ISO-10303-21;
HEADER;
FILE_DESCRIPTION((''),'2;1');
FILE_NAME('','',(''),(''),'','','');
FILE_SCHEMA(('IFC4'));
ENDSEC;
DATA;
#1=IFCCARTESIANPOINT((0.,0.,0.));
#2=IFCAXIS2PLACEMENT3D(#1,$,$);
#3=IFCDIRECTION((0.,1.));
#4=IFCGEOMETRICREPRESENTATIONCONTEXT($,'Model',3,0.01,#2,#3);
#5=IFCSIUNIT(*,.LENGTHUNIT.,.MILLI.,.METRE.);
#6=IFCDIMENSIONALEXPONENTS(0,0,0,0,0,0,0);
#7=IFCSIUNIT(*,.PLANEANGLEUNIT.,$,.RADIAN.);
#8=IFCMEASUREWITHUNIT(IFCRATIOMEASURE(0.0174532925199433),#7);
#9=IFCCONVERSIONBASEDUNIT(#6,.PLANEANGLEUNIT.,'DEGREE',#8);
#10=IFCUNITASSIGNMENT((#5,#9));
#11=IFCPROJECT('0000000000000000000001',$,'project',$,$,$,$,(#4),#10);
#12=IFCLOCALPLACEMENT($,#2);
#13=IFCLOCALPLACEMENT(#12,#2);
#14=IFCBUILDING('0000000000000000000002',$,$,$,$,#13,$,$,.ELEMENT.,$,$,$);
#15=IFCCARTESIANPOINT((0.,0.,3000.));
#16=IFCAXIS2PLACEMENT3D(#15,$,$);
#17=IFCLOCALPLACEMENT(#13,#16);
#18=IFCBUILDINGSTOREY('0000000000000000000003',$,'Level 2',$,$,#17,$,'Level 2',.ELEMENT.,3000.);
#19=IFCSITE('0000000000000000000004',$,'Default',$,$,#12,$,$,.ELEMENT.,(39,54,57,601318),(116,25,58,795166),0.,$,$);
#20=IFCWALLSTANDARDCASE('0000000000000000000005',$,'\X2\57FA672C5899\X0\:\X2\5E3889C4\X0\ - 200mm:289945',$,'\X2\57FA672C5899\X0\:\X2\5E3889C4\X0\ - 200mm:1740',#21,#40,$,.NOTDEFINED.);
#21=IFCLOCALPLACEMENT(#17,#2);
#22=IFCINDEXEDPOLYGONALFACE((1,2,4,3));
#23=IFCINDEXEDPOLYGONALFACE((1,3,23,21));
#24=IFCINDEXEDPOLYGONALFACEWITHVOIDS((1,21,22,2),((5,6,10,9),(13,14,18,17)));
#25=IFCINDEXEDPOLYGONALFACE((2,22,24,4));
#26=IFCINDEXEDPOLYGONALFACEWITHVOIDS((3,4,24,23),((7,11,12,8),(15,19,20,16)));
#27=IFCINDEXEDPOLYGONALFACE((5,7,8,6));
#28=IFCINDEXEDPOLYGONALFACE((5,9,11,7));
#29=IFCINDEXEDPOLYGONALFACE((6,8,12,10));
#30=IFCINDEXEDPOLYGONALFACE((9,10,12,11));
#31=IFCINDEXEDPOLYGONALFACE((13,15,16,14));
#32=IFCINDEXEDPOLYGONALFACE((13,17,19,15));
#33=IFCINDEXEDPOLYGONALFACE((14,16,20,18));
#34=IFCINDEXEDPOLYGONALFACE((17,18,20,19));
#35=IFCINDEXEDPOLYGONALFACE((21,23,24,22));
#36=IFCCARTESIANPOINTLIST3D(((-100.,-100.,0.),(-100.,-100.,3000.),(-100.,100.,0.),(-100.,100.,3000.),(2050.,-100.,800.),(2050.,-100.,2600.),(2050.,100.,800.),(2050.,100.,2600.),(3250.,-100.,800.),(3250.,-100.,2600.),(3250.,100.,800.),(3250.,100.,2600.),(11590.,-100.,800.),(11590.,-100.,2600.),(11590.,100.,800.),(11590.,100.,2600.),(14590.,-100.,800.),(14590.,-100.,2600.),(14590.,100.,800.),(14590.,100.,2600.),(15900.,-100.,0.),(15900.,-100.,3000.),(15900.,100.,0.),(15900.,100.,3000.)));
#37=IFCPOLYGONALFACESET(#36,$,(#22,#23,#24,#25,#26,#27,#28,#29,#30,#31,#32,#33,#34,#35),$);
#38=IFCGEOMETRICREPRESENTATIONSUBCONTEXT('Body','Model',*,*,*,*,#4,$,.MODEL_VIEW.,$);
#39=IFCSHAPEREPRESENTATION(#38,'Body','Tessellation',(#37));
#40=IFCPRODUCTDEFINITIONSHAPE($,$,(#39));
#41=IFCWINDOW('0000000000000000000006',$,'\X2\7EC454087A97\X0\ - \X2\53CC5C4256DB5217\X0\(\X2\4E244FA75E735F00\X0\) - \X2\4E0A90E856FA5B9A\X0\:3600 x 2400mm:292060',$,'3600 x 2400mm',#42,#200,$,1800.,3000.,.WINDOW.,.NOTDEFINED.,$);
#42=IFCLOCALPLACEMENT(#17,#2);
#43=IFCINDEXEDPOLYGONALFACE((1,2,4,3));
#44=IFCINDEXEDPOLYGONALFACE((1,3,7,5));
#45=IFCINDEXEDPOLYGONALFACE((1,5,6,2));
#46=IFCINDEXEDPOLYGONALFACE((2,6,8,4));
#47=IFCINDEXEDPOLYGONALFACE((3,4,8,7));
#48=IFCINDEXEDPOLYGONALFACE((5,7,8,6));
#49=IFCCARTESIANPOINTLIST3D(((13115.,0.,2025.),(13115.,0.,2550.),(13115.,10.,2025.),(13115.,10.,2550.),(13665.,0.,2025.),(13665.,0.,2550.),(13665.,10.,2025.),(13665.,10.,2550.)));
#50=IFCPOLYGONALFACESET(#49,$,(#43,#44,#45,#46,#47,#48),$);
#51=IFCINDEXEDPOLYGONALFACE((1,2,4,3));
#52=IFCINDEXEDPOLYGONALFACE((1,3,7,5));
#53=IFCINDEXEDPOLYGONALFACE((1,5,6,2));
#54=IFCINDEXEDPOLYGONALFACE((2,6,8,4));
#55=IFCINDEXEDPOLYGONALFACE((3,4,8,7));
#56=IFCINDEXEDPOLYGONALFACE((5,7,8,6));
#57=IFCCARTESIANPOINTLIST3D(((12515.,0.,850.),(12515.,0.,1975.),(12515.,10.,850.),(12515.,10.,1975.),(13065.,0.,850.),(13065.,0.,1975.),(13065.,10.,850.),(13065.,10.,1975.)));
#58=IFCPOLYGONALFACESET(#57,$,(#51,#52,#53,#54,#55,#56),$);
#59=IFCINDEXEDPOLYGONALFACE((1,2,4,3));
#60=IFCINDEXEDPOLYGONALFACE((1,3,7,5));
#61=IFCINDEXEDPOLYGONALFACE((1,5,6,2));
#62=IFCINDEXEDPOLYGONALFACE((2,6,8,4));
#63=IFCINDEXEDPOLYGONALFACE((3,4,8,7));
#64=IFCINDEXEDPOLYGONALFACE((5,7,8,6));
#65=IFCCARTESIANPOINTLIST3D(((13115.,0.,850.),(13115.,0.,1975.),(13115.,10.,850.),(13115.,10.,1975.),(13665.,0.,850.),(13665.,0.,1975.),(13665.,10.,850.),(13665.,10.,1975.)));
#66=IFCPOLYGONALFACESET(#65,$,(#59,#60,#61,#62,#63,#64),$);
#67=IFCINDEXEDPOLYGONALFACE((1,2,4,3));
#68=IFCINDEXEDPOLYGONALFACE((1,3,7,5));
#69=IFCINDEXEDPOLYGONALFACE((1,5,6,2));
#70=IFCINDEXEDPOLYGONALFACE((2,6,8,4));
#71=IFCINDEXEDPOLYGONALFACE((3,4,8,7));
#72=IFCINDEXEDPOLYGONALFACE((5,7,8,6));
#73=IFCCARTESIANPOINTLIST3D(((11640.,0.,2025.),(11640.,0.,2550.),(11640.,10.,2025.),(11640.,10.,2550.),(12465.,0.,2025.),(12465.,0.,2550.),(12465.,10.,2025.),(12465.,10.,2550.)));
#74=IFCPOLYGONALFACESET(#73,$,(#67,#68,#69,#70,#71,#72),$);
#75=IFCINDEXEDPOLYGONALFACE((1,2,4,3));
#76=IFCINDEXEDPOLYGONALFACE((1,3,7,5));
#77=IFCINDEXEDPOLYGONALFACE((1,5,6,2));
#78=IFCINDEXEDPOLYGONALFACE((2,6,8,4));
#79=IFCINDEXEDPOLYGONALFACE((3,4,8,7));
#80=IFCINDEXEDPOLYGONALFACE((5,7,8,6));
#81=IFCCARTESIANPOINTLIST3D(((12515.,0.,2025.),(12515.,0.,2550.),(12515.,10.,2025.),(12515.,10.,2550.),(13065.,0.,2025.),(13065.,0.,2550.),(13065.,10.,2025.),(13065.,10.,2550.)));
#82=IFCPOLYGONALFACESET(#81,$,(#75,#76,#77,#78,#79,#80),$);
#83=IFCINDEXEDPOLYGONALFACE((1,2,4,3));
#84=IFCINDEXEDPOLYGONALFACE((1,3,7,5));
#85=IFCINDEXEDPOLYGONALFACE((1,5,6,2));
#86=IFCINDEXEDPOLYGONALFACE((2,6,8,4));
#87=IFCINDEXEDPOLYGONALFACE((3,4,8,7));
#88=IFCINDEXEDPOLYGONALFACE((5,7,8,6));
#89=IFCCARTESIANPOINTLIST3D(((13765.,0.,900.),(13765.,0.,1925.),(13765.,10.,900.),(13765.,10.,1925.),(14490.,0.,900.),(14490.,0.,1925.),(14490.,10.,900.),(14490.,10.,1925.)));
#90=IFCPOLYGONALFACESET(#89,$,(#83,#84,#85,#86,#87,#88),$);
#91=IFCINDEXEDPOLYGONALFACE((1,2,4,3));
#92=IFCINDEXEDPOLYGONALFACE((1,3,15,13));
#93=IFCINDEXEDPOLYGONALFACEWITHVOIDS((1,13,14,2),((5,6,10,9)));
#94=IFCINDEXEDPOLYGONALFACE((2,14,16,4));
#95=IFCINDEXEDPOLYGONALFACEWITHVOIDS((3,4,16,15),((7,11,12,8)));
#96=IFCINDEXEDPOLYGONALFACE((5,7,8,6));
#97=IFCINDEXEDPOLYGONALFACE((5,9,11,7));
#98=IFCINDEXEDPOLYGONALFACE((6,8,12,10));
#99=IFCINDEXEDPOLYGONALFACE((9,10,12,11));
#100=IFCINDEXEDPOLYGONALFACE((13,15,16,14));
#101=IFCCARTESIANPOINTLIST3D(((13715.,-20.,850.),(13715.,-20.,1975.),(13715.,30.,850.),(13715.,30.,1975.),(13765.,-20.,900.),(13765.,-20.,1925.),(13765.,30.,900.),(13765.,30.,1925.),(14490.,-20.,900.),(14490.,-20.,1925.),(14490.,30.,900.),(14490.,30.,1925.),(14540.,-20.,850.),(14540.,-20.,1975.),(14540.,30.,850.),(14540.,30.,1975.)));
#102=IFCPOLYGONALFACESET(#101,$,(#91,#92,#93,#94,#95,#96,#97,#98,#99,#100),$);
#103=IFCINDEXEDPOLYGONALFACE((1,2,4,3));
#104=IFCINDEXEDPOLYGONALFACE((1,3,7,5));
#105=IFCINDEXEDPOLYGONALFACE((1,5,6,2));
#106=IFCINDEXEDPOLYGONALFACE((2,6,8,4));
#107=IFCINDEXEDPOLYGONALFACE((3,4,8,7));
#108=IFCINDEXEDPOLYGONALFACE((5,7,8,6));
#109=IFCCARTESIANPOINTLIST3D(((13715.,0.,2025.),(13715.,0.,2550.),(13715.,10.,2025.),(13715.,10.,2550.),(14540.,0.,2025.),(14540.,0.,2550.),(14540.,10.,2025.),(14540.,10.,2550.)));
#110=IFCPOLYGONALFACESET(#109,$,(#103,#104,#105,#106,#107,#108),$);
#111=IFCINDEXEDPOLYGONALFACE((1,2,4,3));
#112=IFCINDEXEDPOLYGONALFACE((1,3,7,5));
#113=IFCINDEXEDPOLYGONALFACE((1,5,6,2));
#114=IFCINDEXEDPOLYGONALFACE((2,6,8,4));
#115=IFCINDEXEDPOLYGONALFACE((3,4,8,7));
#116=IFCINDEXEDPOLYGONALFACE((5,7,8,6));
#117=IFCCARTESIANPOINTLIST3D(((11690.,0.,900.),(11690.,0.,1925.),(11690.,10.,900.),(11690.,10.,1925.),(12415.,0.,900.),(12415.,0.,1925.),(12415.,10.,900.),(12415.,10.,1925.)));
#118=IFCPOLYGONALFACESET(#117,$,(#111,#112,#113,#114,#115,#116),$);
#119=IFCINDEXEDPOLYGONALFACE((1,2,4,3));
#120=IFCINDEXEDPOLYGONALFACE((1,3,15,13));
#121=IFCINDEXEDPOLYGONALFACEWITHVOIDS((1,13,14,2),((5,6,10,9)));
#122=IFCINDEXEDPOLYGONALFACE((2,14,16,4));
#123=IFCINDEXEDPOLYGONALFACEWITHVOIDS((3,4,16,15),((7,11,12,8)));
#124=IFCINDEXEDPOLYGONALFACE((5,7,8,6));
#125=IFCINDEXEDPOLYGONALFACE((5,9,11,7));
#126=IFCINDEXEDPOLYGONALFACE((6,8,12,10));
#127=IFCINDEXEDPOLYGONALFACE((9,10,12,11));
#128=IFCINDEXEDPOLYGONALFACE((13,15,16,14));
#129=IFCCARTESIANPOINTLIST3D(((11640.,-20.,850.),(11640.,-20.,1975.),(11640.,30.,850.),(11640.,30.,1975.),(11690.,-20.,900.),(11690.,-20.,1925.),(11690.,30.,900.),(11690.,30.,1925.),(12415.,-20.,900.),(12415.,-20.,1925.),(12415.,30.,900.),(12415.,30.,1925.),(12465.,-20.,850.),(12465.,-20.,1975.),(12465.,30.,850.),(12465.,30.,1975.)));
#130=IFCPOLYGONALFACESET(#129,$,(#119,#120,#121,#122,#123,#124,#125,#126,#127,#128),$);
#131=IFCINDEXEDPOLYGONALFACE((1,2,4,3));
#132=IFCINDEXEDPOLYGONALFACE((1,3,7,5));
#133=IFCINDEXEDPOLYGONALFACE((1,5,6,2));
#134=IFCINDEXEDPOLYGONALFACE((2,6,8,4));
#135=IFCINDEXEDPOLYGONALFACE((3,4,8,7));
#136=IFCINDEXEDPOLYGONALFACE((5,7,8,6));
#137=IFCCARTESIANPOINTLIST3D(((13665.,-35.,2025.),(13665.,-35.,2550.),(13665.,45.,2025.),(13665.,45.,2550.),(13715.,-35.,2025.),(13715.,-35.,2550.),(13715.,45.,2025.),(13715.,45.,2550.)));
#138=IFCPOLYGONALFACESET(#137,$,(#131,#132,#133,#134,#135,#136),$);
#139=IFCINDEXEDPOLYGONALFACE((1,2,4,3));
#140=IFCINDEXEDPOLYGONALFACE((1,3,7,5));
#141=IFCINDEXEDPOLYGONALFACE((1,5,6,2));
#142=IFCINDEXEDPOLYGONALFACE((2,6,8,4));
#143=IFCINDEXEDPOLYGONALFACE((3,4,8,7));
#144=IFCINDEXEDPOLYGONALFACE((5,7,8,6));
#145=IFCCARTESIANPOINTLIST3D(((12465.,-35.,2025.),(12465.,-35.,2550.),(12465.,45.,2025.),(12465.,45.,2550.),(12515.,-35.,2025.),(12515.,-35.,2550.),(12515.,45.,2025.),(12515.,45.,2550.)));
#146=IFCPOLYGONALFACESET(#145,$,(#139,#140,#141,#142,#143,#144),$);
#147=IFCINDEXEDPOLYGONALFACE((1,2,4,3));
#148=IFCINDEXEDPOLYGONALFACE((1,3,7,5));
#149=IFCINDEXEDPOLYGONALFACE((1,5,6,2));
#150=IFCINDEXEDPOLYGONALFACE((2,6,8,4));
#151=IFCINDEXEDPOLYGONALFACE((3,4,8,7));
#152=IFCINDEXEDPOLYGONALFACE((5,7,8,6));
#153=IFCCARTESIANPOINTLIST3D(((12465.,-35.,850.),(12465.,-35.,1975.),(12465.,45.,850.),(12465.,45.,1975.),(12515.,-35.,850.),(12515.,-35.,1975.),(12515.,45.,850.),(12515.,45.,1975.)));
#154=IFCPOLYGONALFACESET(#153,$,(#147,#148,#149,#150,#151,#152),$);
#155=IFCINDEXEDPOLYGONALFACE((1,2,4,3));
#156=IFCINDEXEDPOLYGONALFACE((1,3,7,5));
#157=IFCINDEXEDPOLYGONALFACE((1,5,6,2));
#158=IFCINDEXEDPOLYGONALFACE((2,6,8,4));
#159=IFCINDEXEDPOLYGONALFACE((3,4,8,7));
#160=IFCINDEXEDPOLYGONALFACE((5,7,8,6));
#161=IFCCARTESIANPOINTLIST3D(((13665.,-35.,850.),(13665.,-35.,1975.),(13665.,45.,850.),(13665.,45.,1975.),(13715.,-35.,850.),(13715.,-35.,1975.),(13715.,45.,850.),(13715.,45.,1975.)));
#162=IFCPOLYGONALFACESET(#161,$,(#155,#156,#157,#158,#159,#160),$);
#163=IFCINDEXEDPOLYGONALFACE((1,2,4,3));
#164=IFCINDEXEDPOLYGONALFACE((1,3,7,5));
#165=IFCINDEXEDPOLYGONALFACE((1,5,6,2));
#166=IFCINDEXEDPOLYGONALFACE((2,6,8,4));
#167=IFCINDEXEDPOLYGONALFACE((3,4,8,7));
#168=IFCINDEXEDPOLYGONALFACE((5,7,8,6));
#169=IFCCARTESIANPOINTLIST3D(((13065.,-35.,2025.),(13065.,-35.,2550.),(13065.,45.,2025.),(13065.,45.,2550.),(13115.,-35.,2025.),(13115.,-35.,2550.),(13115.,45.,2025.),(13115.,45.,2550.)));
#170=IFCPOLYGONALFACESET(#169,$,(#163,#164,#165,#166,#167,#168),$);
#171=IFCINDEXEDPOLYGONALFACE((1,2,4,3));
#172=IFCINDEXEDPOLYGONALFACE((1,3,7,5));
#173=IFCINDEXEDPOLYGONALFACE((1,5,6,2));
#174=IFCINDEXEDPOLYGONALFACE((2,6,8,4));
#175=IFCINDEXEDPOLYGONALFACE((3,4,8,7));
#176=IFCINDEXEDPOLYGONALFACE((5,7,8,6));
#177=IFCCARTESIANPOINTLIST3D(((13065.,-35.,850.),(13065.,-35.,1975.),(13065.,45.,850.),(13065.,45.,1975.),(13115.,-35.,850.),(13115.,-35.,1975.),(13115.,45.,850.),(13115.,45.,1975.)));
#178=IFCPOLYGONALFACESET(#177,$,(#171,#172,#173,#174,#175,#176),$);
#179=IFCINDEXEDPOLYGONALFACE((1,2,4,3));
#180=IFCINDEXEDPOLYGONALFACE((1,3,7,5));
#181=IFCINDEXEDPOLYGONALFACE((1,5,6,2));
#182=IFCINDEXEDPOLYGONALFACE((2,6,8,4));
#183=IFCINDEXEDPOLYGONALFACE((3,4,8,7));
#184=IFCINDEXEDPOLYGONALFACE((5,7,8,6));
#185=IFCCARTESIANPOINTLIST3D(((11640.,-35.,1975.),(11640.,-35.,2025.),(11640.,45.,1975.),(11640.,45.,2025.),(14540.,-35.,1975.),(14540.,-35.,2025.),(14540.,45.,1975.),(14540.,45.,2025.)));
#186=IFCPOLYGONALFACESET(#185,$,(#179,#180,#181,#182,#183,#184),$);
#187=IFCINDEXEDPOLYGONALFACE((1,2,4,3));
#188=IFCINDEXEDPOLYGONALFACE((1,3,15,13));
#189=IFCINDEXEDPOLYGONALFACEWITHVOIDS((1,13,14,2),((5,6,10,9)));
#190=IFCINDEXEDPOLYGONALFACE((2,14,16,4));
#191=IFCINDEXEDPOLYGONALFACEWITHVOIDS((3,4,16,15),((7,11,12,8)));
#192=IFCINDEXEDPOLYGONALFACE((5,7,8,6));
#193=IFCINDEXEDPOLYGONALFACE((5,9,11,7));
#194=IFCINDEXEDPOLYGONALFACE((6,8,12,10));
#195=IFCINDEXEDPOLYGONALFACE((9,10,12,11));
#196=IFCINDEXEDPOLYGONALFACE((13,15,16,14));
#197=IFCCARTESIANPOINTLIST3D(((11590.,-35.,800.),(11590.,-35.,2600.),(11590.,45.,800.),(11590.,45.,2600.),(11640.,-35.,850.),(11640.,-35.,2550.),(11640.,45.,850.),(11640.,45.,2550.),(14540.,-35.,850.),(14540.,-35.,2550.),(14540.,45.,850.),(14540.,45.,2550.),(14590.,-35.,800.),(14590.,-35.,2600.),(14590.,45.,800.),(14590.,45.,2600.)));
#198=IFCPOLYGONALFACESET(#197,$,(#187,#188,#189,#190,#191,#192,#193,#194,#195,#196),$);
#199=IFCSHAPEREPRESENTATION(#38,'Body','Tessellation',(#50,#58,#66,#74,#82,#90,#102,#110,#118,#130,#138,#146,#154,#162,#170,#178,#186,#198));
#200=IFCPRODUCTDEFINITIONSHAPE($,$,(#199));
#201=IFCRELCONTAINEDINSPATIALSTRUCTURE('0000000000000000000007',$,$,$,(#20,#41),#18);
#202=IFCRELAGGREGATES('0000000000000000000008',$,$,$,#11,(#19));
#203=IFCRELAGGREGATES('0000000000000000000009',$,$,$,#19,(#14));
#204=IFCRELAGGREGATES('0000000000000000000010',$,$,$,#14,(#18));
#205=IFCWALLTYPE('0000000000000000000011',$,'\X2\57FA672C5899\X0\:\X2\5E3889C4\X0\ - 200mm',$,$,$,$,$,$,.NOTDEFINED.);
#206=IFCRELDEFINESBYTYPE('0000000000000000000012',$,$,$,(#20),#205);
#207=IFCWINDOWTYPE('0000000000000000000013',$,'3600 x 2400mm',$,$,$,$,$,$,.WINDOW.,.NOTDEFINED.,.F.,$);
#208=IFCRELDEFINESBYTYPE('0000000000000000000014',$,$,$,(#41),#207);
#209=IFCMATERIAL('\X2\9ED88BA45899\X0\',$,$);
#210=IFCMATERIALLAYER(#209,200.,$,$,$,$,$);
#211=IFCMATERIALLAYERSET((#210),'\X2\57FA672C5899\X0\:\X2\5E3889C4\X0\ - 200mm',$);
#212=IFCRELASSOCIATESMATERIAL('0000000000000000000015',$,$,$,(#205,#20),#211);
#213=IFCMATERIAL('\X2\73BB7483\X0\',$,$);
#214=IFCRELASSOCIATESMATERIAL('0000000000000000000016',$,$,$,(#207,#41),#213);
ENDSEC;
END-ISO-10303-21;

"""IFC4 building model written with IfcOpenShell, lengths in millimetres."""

from ifc_helpers import new_model, entity, si_unit, converted_unit, direction, frame, frame_2d, origin, origin_2d_with_axis, place, context, subcontext, project, spatial, polyline, rectangle, outline, extrude, source, transform, mapped, material, layer, layer_set, layer_usage, type_object, type_shapes, element, fill, save


model = new_model("IFC4")

# Units and contexts
model_context = context("Model", 3, precision=0.01, world=origin(), true_north=direction((0.0, 1.0)))
body_context = subcontext(model_context, "Body", "Model", "MODEL_VIEW")
ifc_project = project(units=[si_unit("LENGTHUNIT", "METRE", prefix="MILLI"), converted_unit("PLANEANGLEUNIT", "DEGREE", entity("IfcRatioMeasure", 0.0174532925199433), si_unit("PLANEANGLEUNIT", "RADIAN"), dimensions=[0, 0, 0, 0, 0, 0, 0])], contexts=[model_context])

# Site, building, storey
site_placement = place(None, origin())
site = spatial("IfcSite", under=ifc_project, at=site_placement, Name="Default", CompositionType="ELEMENT", RefLatitude=(39, 54, 57, 601318), RefLongitude=(116, 25, 58, 795166), RefElevation=0.0)
building_placement = place(site_placement, origin())
building = spatial("IfcBuilding", under=site, at=building_placement, CompositionType="ELEMENT")
storey_placement = place(building_placement, frame((0.0, 0.0, 3000.0)))
storey = spatial("IfcBuildingStorey", under=building, at=storey_placement, Name="Level 2", LongName="Level 2", CompositionType="ELEMENT", Elevation=3000.0)

# Shared definitions
ifc_material_1 = material(Name="默认墙")
ifc_layer = layer(ifc_material_1, 200.0)
ifc_layer_set = layer_set([ifc_layer], Name="基本墙:常规 - 200mm")
wall_type = type_object("IfcWallType", Name="基本墙:常规 - 200mm", PredefinedType="NOTDEFINED", material=ifc_layer_set)

# Shared definitions
ifc_material_2 = material(Name="玻璃")

# Wall, openings, window
ifc_layer_usage_1 = layer_usage(ifc_layer_set, "AXIS2", "NEGATIVE", 100.0)
wall_1_placement = place(storey_placement, frame((15900.0, 0.0, 0.0), z_axis=(0.0, 0.0, 1.0), x_axis=(-1.0, 0.0, 0.0)))
wall_1 = element("IfcWallStandardCase", 1, at=wall_1_placement, inside=storey, type_object=wall_type, material=ifc_layer_usage_1, Name="基本墙:常规 - 200mm:289945", ObjectType="基本墙:常规 - 200mm:1740", PredefinedType="NOTDEFINED", context=body_context, shape_type="SweptSolid", body=[
    extrude(rectangle(XDim=16000.0, YDim=200.0, at=frame_2d((8000.0, 0.0), x_axis=(-1.0, 0.0))), origin(), (0.0, 0.0, 1.0), 3000.0),
])
opening_1_placement = place(wall_1_placement, frame((12650.0, -100.0, 800.0)))
element("IfcOpeningElement", 2, at=opening_1_placement, cuts=wall_1, ObjectType="Opening", PredefinedType="OPENING", context=body_context, shape_type="SweptSolid", body=[
    extrude(rectangle(XDim=1800.0, YDim=1200.0, at=frame_2d((900.0, 600.0), x_axis=(1.0, 0.0))), frame((0.0, 0.0, 0.0), z_axis=(0.0, 1.0, 0.0), x_axis=(0.0, 0.0, 1.0)), (0.0, 0.0, 1.0), 200.0),
])
opening_2_placement = place(wall_1_placement, frame((1310.0, -100.0, 800.0)))
opening_2 = element("IfcOpeningElement", 3, at=opening_2_placement, cuts=wall_1, ObjectType="Opening", PredefinedType="OPENING", context=body_context, shape_type="SweptSolid", body=[
    extrude(rectangle(XDim=1800.0, YDim=3000.0, at=frame_2d((900.0, 1500.0), x_axis=(1.0, 0.0))), frame((0.0, 0.0, 0.0), z_axis=(0.0, 1.0, 0.0), x_axis=(0.0, 0.0, 1.0)), (0.0, 0.0, 1.0), 200.0),
])
window_type_1 = type_object("IfcWindowType", Name="3600 x 2400mm", ParameterTakesPrecedence=False, PartitioningType="NOTDEFINED", PredefinedType="WINDOW", material=ifc_material_2)
shared_shape_1 = source(origin(), body_context, "Body", "SweptSolid", [
    extrude(rectangle(XDim=10.0, YDim=550.0, at=origin_2d_with_axis()), frame((1200.0, 95.0, 1225.0), z_axis=(0.0, 0.0, 1.0), x_axis=(0.0, 1.0, 0.0)), (0.0, 0.0, 1.0), 525.0),
    extrude(rectangle(XDim=10.0, YDim=550.0, at=origin_2d_with_axis()), frame((1800.0, 95.0, 50.0), z_axis=(0.0, 0.0, 1.0), x_axis=(0.0, 1.0, 0.0)), (0.0, 0.0, 1.0), 1125.0),
    extrude(rectangle(XDim=10.0, YDim=550.0, at=origin_2d_with_axis()), frame((1200.0, 95.0, 50.0), z_axis=(0.0, 0.0, 1.0), x_axis=(0.0, 1.0, 0.0)), (0.0, 0.0, 1.0), 1125.0),
    extrude(rectangle(XDim=10.0, YDim=825.0, at=origin_2d_with_axis()), frame((2537.5, 95.0, 1225.0), z_axis=(0.0, 0.0, 1.0), x_axis=(0.0, 1.0, 0.0)), (0.0, 0.0, 1.0), 525.0),
    extrude(rectangle(XDim=10.0, YDim=550.0, at=origin_2d_with_axis()), frame((1800.0, 95.0, 1225.0), z_axis=(0.0, 0.0, 1.0), x_axis=(0.0, 1.0, 0.0)), (0.0, 0.0, 1.0), 525.0),
    extrude(rectangle(XDim=10.0, YDim=725.0, at=origin_2d_with_axis()), frame((462.5, 95.0, 100.0), z_axis=(0.0, 0.0, 1.0), x_axis=(0.0, 1.0, 0.0)), (0.0, 0.0, 1.0), 1025.0),
    extrude(outline(polyline([(-562.5, -412.5), (562.5, -412.5), (562.5, 412.5), (-562.5, 412.5), (-562.5, -412.5)]), holes=[polyline([(512.5, -362.5), (-512.5, -362.5), (-512.5, 362.5), (512.5, 362.5), (512.5, -362.5)])]), frame((462.5, 70.0, 612.5), z_axis=(0.0, 1.0, 0.0), x_axis=(0.0, 0.0, -1.0)), (0.0, 0.0, 1.0), 50.0),
    extrude(rectangle(XDim=10.0, YDim=825.0, at=origin_2d_with_axis()), frame((462.5, 95.0, 1225.0), z_axis=(0.0, 0.0, 1.0), x_axis=(0.0, 1.0, 0.0)), (0.0, 0.0, 1.0), 525.0),
    extrude(rectangle(XDim=10.0, YDim=725.0, at=origin_2d_with_axis()), frame((2537.5, 95.0, 100.0), z_axis=(0.0, 0.0, 1.0), x_axis=(0.0, 1.0, 0.0)), (0.0, 0.0, 1.0), 1025.0),
    extrude(outline(polyline([(-562.5, -412.5), (562.5, -412.5), (562.5, 412.5), (-562.5, 412.5), (-562.5, -412.5)]), holes=[polyline([(512.5, -362.5), (-512.5, -362.5), (-512.5, 362.5), (512.5, 362.5), (512.5, -362.5)])]), frame((2537.5, 70.0, 612.5), z_axis=(0.0, 1.0, 0.0), x_axis=(0.0, 0.0, -1.0)), (0.0, 0.0, 1.0), 50.0),
    extrude(rectangle(XDim=80.0, YDim=50.0, at=origin_2d_with_axis()), frame((900.0, 95.0, 1225.0), z_axis=(0.0, 0.0, 1.0), x_axis=(0.0, -1.0, 0.0)), (0.0, 0.0, 1.0), 525.0),
    extrude(rectangle(XDim=80.0, YDim=50.0, at=origin_2d_with_axis()), frame((2100.0, 95.0, 1225.0), z_axis=(0.0, 0.0, 1.0), x_axis=(0.0, -1.0, 0.0)), (0.0, 0.0, 1.0), 525.0),
    extrude(rectangle(XDim=80.0, YDim=50.0, at=origin_2d_with_axis()), frame((2100.0, 95.0, 50.0), z_axis=(0.0, 0.0, 1.0), x_axis=(0.0, -1.0, 0.0)), (0.0, 0.0, 1.0), 1125.0),
    extrude(rectangle(XDim=80.0, YDim=50.0, at=origin_2d_with_axis()), frame((900.0, 95.0, 50.0), z_axis=(0.0, 0.0, 1.0), x_axis=(0.0, -1.0, 0.0)), (0.0, 0.0, 1.0), 1125.0),
    extrude(rectangle(XDim=80.0, YDim=50.0, at=origin_2d_with_axis()), frame((1500.0, 95.0, 1225.0), z_axis=(0.0, 0.0, 1.0), x_axis=(0.0, -1.0, 0.0)), (0.0, 0.0, 1.0), 525.0),
    extrude(rectangle(XDim=80.0, YDim=50.0, at=origin_2d_with_axis()), frame((1500.0, 95.0, 50.0), z_axis=(0.0, 0.0, 1.0), x_axis=(0.0, -1.0, 0.0)), (0.0, 0.0, 1.0), 1125.0),
    extrude(rectangle(XDim=80.0, YDim=2900.0, at=origin_2d_with_axis()), frame((1500.0, 95.0, 1175.0), z_axis=(0.0, 0.0, 1.0), x_axis=(0.0, -1.0, 0.0)), (0.0, 0.0, 1.0), 50.0),
    extrude(outline(polyline([(-1500.0, -900.0), (1500.0, -900.0), (1500.0, 900.0), (-1500.0, 900.0), (-1500.0, -900.0)]), holes=[polyline([(1450.0, -850.0), (-1450.0, -850.0), (-1450.0, 850.0), (1450.0, 850.0), (1450.0, -850.0)])]), frame((1500.0, 55.0, 900.0), z_axis=(0.0, 1.0, 0.0), x_axis=(1.0, 0.0, 0.0)), (0.0, 0.0, 1.0), 80.0),
])
type_shapes(window_type_1, [shared_shape_1])
window_1_placement = place(opening_2_placement, origin())
window_1 = element("IfcWindow", 4, at=window_1_placement, inside=storey, type_object=window_type_1, material=ifc_material_2, Name="组合窗 - 双层四列(两侧平开) - 上部固定:3600 x 2400mm:292060", ObjectType="3600 x 2400mm", OverallHeight=1800.0, OverallWidth=3000.0, PartitioningType="NOTDEFINED", PredefinedType="WINDOW", context=body_context, shape_type="MappedRepresentation", body=[
    mapped(shared_shape_1, transform((0.0, 0.0, 0.0), scale=1.0)),
])
fill(opening_2, window_1)

save(model, "model.ifc")
